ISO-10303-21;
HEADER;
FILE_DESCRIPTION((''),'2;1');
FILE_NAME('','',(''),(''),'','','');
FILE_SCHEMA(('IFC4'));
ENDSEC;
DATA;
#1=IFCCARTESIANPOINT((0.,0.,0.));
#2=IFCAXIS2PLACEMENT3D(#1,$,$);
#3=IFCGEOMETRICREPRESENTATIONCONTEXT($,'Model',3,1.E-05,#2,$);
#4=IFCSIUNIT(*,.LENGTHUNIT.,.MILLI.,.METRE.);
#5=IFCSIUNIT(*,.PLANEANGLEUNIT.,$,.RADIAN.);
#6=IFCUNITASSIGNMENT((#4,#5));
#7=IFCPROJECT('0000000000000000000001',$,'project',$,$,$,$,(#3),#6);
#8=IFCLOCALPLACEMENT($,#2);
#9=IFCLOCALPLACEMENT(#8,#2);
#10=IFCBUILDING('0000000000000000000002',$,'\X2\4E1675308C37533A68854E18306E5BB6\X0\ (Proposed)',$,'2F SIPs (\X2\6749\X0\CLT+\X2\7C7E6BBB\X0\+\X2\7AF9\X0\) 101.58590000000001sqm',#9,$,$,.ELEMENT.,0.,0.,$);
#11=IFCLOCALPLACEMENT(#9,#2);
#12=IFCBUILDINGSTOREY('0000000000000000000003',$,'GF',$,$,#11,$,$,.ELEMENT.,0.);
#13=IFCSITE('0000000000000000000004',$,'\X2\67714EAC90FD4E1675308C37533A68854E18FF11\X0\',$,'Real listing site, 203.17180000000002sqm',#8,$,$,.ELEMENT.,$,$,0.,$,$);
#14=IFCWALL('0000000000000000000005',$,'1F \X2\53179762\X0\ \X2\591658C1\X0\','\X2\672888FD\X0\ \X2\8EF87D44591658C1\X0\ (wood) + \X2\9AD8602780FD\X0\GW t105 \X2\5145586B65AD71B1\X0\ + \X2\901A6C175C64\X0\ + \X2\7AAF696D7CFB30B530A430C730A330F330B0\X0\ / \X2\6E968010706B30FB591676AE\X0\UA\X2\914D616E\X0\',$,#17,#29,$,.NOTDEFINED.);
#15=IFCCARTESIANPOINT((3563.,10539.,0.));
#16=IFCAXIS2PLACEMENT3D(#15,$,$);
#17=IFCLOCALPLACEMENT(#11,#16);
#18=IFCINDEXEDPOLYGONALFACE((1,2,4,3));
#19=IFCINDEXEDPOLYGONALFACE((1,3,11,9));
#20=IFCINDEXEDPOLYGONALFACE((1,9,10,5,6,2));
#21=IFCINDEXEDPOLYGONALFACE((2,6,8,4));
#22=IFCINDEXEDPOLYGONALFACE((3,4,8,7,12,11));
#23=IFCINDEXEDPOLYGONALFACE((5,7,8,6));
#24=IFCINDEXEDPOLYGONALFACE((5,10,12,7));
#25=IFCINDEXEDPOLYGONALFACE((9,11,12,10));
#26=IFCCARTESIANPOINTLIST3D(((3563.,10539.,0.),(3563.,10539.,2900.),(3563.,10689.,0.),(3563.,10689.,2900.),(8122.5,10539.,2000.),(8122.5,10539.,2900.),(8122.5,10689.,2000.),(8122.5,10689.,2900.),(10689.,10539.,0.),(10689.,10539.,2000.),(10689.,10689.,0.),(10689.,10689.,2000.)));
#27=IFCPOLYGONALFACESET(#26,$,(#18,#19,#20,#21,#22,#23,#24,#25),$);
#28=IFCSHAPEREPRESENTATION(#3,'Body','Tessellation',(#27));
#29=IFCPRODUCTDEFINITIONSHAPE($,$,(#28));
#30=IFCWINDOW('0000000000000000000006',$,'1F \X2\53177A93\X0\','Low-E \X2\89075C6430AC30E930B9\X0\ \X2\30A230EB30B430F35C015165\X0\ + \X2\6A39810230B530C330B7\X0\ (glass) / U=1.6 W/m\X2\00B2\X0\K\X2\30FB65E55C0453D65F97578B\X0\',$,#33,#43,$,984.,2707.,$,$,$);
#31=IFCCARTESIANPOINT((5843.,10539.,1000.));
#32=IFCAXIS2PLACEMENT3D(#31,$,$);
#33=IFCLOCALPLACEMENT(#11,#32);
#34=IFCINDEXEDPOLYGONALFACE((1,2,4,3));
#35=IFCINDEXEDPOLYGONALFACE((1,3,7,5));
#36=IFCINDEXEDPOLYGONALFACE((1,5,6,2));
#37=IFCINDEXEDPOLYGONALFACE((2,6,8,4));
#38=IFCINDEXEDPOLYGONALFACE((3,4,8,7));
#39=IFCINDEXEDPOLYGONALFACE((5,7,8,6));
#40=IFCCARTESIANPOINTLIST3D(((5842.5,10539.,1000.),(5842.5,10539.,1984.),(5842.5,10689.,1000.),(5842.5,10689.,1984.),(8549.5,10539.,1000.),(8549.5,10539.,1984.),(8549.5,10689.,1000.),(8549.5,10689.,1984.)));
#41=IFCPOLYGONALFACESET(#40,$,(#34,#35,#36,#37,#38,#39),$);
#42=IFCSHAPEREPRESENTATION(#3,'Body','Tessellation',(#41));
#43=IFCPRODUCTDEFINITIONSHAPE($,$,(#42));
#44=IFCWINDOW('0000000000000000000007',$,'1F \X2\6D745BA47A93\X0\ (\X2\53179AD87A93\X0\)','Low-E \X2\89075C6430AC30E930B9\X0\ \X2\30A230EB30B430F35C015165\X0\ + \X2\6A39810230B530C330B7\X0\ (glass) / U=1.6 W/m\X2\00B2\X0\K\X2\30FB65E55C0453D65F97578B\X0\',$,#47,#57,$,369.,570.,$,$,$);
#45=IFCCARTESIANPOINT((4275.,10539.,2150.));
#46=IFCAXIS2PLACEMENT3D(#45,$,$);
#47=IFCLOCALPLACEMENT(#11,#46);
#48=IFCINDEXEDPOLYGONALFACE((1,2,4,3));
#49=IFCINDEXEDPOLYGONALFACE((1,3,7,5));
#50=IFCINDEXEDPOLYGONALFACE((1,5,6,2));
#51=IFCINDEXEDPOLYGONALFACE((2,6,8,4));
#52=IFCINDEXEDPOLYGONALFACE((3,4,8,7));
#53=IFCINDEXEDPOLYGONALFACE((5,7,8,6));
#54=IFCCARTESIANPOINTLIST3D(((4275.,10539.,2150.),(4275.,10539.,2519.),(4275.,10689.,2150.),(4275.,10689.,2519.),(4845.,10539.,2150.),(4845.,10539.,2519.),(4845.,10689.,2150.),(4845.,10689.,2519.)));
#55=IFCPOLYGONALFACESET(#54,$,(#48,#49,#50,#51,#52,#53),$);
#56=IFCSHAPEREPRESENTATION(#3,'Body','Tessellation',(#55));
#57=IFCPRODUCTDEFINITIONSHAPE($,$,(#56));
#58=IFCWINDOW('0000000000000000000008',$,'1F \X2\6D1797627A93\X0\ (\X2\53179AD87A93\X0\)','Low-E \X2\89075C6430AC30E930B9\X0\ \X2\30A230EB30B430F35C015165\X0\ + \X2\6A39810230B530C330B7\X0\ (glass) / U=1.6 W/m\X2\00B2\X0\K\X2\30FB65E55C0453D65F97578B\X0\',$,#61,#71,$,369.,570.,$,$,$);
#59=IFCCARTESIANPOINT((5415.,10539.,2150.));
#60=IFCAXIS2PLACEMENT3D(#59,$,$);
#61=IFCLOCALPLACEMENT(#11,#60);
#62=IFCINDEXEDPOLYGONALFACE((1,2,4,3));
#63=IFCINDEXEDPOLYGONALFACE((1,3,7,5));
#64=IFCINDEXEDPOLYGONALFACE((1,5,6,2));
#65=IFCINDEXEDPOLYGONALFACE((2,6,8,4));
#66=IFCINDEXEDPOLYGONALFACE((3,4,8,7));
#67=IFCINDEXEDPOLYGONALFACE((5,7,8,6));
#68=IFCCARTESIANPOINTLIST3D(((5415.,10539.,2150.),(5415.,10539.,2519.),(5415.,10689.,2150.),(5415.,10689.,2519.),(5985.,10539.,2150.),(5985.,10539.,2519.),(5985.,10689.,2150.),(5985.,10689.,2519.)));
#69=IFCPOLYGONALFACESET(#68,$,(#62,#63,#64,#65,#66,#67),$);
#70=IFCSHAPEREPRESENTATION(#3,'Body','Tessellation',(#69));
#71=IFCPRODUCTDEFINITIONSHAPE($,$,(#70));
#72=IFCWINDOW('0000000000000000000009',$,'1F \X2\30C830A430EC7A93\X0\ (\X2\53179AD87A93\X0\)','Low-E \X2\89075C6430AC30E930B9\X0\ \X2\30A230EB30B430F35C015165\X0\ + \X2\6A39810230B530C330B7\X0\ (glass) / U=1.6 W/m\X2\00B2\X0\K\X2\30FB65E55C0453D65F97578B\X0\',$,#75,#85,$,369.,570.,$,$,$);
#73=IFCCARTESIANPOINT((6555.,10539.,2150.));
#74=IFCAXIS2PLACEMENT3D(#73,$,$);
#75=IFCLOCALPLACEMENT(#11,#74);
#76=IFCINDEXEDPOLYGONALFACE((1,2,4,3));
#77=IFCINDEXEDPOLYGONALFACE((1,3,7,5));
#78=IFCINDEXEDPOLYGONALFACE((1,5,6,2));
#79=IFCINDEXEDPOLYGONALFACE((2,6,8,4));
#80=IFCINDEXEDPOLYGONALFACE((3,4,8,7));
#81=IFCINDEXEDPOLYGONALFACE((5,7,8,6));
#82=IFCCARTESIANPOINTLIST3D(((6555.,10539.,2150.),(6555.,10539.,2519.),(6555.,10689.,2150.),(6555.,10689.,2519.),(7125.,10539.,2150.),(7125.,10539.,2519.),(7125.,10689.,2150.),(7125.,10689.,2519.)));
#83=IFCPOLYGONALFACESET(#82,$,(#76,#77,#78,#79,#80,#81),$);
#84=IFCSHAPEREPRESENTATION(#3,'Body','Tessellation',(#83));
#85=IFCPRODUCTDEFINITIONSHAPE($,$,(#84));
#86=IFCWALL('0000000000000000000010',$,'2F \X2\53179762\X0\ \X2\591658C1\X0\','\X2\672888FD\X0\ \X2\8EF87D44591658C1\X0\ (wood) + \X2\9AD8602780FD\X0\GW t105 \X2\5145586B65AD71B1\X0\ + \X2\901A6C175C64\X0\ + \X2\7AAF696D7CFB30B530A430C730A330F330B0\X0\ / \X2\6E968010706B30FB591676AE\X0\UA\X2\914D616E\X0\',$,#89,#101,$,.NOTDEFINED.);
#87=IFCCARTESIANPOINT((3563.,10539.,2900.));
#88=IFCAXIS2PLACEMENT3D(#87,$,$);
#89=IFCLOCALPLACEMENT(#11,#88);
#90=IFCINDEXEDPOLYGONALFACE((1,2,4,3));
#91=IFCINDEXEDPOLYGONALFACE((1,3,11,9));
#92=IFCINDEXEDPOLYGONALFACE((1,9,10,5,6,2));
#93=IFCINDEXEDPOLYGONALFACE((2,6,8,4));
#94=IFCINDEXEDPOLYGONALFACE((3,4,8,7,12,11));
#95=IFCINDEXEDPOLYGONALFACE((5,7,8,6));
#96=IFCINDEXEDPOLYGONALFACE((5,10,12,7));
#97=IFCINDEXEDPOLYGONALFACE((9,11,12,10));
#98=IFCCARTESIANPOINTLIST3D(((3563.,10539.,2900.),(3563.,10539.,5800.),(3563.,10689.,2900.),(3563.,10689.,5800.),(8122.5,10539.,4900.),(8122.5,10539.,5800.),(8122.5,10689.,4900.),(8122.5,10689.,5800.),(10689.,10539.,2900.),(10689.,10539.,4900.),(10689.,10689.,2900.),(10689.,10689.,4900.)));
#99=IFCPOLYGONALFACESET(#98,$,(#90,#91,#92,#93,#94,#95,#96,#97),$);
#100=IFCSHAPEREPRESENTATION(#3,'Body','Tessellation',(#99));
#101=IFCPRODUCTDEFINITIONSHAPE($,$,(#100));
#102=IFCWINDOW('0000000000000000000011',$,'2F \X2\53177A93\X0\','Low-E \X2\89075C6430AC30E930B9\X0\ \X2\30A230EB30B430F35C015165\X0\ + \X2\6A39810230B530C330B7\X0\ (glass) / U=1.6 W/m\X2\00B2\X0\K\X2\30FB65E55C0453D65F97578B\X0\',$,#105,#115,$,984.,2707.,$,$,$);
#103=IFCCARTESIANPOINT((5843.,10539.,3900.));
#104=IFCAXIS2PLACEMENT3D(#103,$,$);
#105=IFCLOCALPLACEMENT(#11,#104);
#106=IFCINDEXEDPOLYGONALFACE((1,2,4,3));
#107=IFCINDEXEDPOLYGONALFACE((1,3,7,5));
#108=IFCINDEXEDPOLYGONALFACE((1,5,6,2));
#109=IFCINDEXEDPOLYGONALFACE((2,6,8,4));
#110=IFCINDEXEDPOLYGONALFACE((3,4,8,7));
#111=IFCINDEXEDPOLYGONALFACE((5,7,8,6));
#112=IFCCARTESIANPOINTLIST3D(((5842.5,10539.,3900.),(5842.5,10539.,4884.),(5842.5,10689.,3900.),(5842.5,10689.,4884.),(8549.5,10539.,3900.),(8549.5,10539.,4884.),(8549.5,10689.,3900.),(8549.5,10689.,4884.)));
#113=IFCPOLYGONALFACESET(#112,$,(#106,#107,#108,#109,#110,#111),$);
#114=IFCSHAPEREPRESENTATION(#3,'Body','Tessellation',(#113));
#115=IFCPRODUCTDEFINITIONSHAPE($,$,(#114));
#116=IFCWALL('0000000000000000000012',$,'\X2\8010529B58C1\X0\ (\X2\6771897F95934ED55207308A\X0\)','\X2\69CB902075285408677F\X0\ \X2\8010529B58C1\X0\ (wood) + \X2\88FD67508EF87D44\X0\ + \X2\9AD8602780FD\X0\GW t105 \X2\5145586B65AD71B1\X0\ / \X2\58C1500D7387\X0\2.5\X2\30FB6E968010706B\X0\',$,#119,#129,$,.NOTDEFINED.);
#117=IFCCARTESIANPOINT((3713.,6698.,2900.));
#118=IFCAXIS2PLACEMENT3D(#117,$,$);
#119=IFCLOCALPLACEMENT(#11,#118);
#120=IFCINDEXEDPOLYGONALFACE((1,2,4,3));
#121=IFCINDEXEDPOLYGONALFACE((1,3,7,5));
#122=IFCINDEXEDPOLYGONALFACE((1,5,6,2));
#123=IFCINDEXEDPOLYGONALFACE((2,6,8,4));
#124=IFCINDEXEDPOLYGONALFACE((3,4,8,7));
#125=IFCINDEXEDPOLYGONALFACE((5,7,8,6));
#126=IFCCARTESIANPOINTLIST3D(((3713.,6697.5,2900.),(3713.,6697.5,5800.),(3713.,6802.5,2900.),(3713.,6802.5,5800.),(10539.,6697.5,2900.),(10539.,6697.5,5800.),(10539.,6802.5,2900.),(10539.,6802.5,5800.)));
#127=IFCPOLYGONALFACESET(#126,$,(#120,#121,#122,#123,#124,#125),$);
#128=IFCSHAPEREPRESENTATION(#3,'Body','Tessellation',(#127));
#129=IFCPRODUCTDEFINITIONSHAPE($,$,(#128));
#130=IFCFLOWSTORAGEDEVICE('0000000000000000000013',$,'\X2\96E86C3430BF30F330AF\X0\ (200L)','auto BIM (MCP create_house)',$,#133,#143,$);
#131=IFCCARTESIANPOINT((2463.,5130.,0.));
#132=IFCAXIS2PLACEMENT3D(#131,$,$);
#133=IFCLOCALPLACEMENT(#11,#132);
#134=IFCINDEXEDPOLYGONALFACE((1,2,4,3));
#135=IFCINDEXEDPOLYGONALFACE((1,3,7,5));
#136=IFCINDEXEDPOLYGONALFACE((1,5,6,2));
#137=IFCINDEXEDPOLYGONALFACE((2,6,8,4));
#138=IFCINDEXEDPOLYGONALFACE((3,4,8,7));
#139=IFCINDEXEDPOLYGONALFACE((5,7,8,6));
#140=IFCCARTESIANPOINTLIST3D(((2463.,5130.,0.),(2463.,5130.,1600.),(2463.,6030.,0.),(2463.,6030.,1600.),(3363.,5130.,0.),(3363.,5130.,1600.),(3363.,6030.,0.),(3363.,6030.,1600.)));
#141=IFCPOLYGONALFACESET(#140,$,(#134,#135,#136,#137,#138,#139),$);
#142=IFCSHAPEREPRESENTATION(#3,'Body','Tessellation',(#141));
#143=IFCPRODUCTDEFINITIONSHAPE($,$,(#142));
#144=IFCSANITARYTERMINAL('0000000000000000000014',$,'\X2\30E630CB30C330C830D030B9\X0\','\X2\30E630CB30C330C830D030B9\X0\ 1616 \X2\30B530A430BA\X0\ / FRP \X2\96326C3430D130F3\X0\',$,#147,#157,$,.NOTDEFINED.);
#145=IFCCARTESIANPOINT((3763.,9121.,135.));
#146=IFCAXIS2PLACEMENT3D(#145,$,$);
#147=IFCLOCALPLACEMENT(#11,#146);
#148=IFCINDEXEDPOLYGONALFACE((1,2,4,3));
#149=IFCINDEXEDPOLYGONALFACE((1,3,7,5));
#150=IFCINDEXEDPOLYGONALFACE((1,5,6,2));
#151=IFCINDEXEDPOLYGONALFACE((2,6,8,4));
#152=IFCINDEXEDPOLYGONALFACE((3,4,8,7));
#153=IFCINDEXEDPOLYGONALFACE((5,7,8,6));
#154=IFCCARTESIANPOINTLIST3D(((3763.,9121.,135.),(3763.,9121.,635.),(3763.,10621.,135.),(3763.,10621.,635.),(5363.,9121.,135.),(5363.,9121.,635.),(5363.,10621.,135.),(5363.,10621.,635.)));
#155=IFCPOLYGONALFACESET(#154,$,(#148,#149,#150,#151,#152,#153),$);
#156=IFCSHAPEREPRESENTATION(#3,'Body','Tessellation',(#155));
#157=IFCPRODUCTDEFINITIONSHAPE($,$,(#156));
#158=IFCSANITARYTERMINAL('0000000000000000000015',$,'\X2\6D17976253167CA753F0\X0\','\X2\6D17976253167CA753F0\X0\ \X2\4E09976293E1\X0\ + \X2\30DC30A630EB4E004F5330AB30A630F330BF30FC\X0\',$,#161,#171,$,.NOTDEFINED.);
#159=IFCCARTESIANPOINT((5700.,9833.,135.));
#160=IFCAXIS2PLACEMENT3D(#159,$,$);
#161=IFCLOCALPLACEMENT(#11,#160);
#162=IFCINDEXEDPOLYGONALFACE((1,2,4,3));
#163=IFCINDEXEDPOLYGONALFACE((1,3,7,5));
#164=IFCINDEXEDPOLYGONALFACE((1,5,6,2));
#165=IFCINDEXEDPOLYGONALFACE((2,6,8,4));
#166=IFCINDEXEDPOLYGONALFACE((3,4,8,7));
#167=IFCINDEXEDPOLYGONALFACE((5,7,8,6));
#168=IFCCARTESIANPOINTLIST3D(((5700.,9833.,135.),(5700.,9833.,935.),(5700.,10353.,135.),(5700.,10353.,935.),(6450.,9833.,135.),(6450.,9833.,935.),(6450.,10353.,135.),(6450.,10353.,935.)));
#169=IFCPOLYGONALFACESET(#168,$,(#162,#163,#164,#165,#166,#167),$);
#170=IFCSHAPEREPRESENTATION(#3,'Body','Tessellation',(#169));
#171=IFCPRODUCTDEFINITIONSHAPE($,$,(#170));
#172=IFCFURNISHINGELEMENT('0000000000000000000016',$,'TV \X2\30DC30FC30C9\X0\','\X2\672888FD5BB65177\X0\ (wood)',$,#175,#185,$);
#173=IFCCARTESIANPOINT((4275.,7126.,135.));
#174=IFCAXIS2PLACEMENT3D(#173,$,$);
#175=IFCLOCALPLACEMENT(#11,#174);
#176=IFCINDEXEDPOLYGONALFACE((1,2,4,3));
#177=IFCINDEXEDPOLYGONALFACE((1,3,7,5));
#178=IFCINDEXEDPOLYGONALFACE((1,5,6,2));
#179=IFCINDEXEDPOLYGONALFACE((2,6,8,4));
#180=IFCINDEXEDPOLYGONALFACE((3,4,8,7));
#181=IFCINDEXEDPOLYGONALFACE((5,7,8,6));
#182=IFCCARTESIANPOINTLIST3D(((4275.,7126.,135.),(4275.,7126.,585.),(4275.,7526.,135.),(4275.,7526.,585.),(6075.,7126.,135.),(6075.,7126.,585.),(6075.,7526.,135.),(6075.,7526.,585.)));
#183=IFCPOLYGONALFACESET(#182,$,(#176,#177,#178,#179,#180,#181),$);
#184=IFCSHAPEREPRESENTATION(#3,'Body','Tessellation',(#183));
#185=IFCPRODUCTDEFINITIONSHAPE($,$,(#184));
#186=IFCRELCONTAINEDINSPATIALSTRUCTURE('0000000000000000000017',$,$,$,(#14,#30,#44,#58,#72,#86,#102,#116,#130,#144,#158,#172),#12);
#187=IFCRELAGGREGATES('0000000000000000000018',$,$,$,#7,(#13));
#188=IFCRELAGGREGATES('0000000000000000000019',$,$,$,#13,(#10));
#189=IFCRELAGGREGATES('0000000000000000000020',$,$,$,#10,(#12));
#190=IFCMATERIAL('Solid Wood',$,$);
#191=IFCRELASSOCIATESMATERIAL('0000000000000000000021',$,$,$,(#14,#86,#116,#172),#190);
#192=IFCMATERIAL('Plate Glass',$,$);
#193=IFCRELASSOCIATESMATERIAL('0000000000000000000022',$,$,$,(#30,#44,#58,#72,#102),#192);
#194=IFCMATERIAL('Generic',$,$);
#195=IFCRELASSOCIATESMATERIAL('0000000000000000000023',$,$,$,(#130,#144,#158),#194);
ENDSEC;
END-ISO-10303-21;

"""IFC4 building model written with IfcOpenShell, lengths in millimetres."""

from ifc_helpers import new_model, si_unit, frame, frame_2d, origin, place, context, project, spatial, rectangle, extrude, material, element, fill, save


model = new_model("IFC4")

# Units and contexts
model_context = context("Model", 3, precision=1e-05, world=origin())
ifc_project = project(units=[si_unit("LENGTHUNIT", "METRE", prefix="MILLI"), si_unit("PLANEANGLEUNIT", "RADIAN")], contexts=[model_context])

# Site, building, storey
site_placement = place(None, origin())
site = spatial("IfcSite", under=ifc_project, at=site_placement, Name="東京都世田谷区梅丘１", ObjectType="Real listing site, 203.17180000000002sqm", CompositionType="ELEMENT", RefElevation=0.0)
building_placement = place(site_placement, origin())
building = spatial("IfcBuilding", under=site, at=building_placement, Name="世田谷区梅丘の家 (Proposed)", ObjectType="2F SIPs (杉CLT+籾殻+竹) 101.58590000000001sqm", CompositionType="ELEMENT", ElevationOfRefHeight=0.0, ElevationOfTerrain=0.0)
storey_placement = place(building_placement, origin())
storey = spatial("IfcBuildingStorey", under=building, at=storey_placement, Name="GF", CompositionType="ELEMENT", Elevation=0.0)

# Wall, openings, windows
ifc_material_1 = material(Name="Solid Wood")
wall_1_placement = place(storey_placement, frame((3563.0, 10539.0, 0.0)))
wall_1 = element("IfcWall", 1, at=wall_1_placement, inside=storey, material=ifc_material_1, Name="1F 北面 外壁", Description="木製 軸組外壁 (wood) + 高性能GW t105 充填断熱 + 通気層 + 窯業系サイディング / 準耐火・外皮UA配慮", PredefinedType="NOTDEFINED", context=model_context, shape_type="SweptSolid", body=[
    extrude(rectangle(XDim=7126.0, YDim=150.0, at=frame_2d((3563.0, 75.0))), frame((3563.0, 10539.0, 0.0)), (0.0, 0.0, 1.0), 2900.0),
])
opening_1_placement = place(storey_placement, frame((5843.0, 10539.0, 1000.0)))
opening_1 = element("IfcOpeningElement", 2, at=opening_1_placement, cuts=wall_1, PredefinedType="NOTDEFINED", context=model_context, shape_type="SweptSolid", body=[
    extrude(rectangle(XDim=2707.0, YDim=150.0, at=frame_2d((1353.0, 75.0))), frame((5843.0, 10539.0, 1000.0)), (0.0, 0.0, 1.0), 984.0),
])
opening_2_placement = place(storey_placement, frame((4275.0, 10539.0, 2150.0)))
opening_2 = element("IfcOpeningElement", 3, at=opening_2_placement, cuts=wall_1, PredefinedType="NOTDEFINED", context=model_context, shape_type="SweptSolid", body=[
    extrude(rectangle(XDim=570.0, YDim=150.0, at=frame_2d((285.0, 75.0))), frame((4275.0, 10539.0, 2150.0)), (0.0, 0.0, 1.0), 369.0),
])
opening_3_placement = place(storey_placement, frame((5415.0, 10539.0, 2150.0)))
opening_3 = element("IfcOpeningElement", 4, at=opening_3_placement, cuts=wall_1, PredefinedType="NOTDEFINED", context=model_context, shape_type="SweptSolid", body=[
    extrude(rectangle(XDim=570.0, YDim=150.0, at=frame_2d((285.0, 75.0))), frame((5415.0, 10539.0, 2150.0)), (0.0, 0.0, 1.0), 369.0),
])
opening_4_placement = place(storey_placement, frame((6555.0, 10539.0, 2150.0)))
opening_4 = element("IfcOpeningElement", 5, at=opening_4_placement, cuts=wall_1, PredefinedType="NOTDEFINED", context=model_context, shape_type="SweptSolid", body=[
    extrude(rectangle(XDim=570.0, YDim=150.0, at=frame_2d((285.0, 75.0))), frame((6555.0, 10539.0, 2150.0)), (0.0, 0.0, 1.0), 369.0),
])
ifc_material_2 = material(Name="Plate Glass")
window_1_placement = place(storey_placement, frame((5843.0, 10539.0, 1000.0)))
window_1 = element("IfcWindow", 6, at=window_1_placement, inside=storey, material=ifc_material_2, Name="1F 北窓", Description="Low-E 複層ガラス アルゴン封入 + 樹脂サッシ (glass) / U=1.6 W/m²K・日射取得型", OverallHeight=984.0, OverallWidth=2707.0, context=model_context, shape_type="SweptSolid", body=[
    extrude(rectangle(XDim=2707.0, YDim=150.0, at=frame_2d((1353.0, 75.0))), frame((5843.0, 10539.0, 1000.0)), (0.0, 0.0, 1.0), 984.0),
])
fill(opening_1, window_1)
window_2_placement = place(storey_placement, frame((4275.0, 10539.0, 2150.0)))
window_2 = element("IfcWindow", 7, at=window_2_placement, inside=storey, material=ifc_material_2, Name="1F 浴室窓 (北高窓)", Description="Low-E 複層ガラス アルゴン封入 + 樹脂サッシ (glass) / U=1.6 W/m²K・日射取得型", OverallHeight=369.0, OverallWidth=570.0, context=model_context, shape_type="SweptSolid", body=[
    extrude(rectangle(XDim=570.0, YDim=150.0, at=frame_2d((285.0, 75.0))), frame((4275.0, 10539.0, 2150.0)), (0.0, 0.0, 1.0), 369.0),
])
fill(opening_2, window_2)
window_3_placement = place(storey_placement, frame((5415.0, 10539.0, 2150.0)))
window_3 = element("IfcWindow", 8, at=window_3_placement, inside=storey, material=ifc_material_2, Name="1F 洗面窓 (北高窓)", Description="Low-E 複層ガラス アルゴン封入 + 樹脂サッシ (glass) / U=1.6 W/m²K・日射取得型", OverallHeight=369.0, OverallWidth=570.0, context=model_context, shape_type="SweptSolid", body=[
    extrude(rectangle(XDim=570.0, YDim=150.0, at=frame_2d((285.0, 75.0))), frame((5415.0, 10539.0, 2150.0)), (0.0, 0.0, 1.0), 369.0),
])
fill(opening_3, window_3)
window_4_placement = place(storey_placement, frame((6555.0, 10539.0, 2150.0)))
window_4 = element("IfcWindow", 9, at=window_4_placement, inside=storey, material=ifc_material_2, Name="1F トイレ窓 (北高窓)", Description="Low-E 複層ガラス アルゴン封入 + 樹脂サッシ (glass) / U=1.6 W/m²K・日射取得型", OverallHeight=369.0, OverallWidth=570.0, context=model_context, shape_type="SweptSolid", body=[
    extrude(rectangle(XDim=570.0, YDim=150.0, at=frame_2d((285.0, 75.0))), frame((6555.0, 10539.0, 2150.0)), (0.0, 0.0, 1.0), 369.0),
])
fill(opening_4, window_4)

# Wall, opening, window
wall_2_placement = place(storey_placement, frame((3563.0, 10539.0, 2900.0)))
wall_2 = element("IfcWall", 10, at=wall_2_placement, inside=storey, material=ifc_material_1, Name="2F 北面 外壁", Description="木製 軸組外壁 (wood) + 高性能GW t105 充填断熱 + 通気層 + 窯業系サイディング / 準耐火・外皮UA配慮", PredefinedType="NOTDEFINED", context=model_context, shape_type="SweptSolid", body=[
    extrude(rectangle(XDim=7126.0, YDim=150.0, at=frame_2d((3563.0, 75.0))), frame((3563.0, 10539.0, 2900.0)), (0.0, 0.0, 1.0), 2900.0),
])
opening_5_placement = place(storey_placement, frame((5843.0, 10539.0, 3900.0)))
opening_5 = element("IfcOpeningElement", 11, at=opening_5_placement, cuts=wall_2, PredefinedType="NOTDEFINED", context=model_context, shape_type="SweptSolid", body=[
    extrude(rectangle(XDim=2707.0, YDim=150.0, at=frame_2d((1353.0, 75.0))), frame((5843.0, 10539.0, 3900.0)), (0.0, 0.0, 1.0), 984.0),
])
window_5_placement = place(storey_placement, frame((5843.0, 10539.0, 3900.0)))
window_5 = element("IfcWindow", 12, at=window_5_placement, inside=storey, material=ifc_material_2, Name="2F 北窓", Description="Low-E 複層ガラス アルゴン封入 + 樹脂サッシ (glass) / U=1.6 W/m²K・日射取得型", OverallHeight=984.0, OverallWidth=2707.0, context=model_context, shape_type="SweptSolid", body=[
    extrude(rectangle(XDim=2707.0, YDim=150.0, at=frame_2d((1353.0, 75.0))), frame((5843.0, 10539.0, 3900.0)), (0.0, 0.0, 1.0), 984.0),
])
fill(opening_5, window_5)

# Wall
wall_3_placement = place(storey_placement, frame((3713.0, 6698.0, 2900.0)))
element("IfcWall", 13, at=wall_3_placement, inside=storey, material=ifc_material_1, Name="耐力壁 (東西間仕切り)", Description="構造用合板 耐力壁 (wood) + 製材軸組 + 高性能GW t105 充填断熱 / 壁倍率2.5・準耐火", PredefinedType="NOTDEFINED", context=model_context, shape_type="SweptSolid", body=[
    extrude(rectangle(XDim=6826.0, YDim=105.0, at=frame_2d((3413.0, 52.0))), frame((3713.0, 6698.0, 2900.0)), (0.0, 0.0, 1.0), 2900.0),
])

# Flow storage device
ifc_material_3 = material(Name="Generic")
flow_storage_device_placement = place(storey_placement, frame((2463.0, 5130.0, 0.0)))
element("IfcFlowStorageDevice", 14, at=flow_storage_device_placement, inside=storey, material=ifc_material_3, Name="雨水タンク (200L)", Description="auto BIM (MCP create_house)", context=model_context, shape_type="SweptSolid", body=[
    extrude(rectangle(XDim=900.0, YDim=900.0, at=frame_2d((450.0, 450.0))), frame((2463.0, 5130.0, 0.0)), (0.0, 0.0, 1.0), 1600.0),
])

# Sanitary terminals
sanitary_terminal_1_placement = place(storey_placement, frame((3763.0, 9121.0, 135.0)))
element("IfcSanitaryTerminal", 15, at=sanitary_terminal_1_placement, inside=storey, material=ifc_material_3, Name="ユニットバス", Description="ユニットバス 1616 サイズ / FRP 防水パン", PredefinedType="NOTDEFINED", context=model_context, shape_type="SweptSolid", body=[
    extrude(rectangle(XDim=1600.0, YDim=1500.0, at=frame_2d((800.0, 750.0))), frame((3763.0, 9121.0, 135.0)), (0.0, 0.0, 1.0), 500.0),
])
sanitary_terminal_2_placement = place(storey_placement, frame((5700.0, 9833.0, 135.0)))
element("IfcSanitaryTerminal", 16, at=sanitary_terminal_2_placement, inside=storey, material=ifc_material_3, Name="洗面化粧台", Description="洗面化粧台 三面鏡 + ボウル一体カウンター", PredefinedType="NOTDEFINED", context=model_context, shape_type="SweptSolid", body=[
    extrude(rectangle(XDim=750.0, YDim=520.0, at=frame_2d((375.0, 260.0))), frame((5700.0, 9833.0, 135.0)), (0.0, 0.0, 1.0), 800.0),
])

# Furnishing element
furnishing_1_placement = place(storey_placement, frame((4275.0, 7126.0, 135.0)))
element("IfcFurnishingElement", 17, at=furnishing_1_placement, inside=storey, material=ifc_material_1, Name="TV ボード", Description="木製家具 (wood)", context=model_context, shape_type="SweptSolid", body=[
    extrude(rectangle(XDim=1800.0, YDim=400.0, at=frame_2d((900.0, 200.0))), frame((4275.0, 7126.0, 135.0)), (0.0, 0.0, 1.0), 450.0),
])

save(model, "model.ifc")
